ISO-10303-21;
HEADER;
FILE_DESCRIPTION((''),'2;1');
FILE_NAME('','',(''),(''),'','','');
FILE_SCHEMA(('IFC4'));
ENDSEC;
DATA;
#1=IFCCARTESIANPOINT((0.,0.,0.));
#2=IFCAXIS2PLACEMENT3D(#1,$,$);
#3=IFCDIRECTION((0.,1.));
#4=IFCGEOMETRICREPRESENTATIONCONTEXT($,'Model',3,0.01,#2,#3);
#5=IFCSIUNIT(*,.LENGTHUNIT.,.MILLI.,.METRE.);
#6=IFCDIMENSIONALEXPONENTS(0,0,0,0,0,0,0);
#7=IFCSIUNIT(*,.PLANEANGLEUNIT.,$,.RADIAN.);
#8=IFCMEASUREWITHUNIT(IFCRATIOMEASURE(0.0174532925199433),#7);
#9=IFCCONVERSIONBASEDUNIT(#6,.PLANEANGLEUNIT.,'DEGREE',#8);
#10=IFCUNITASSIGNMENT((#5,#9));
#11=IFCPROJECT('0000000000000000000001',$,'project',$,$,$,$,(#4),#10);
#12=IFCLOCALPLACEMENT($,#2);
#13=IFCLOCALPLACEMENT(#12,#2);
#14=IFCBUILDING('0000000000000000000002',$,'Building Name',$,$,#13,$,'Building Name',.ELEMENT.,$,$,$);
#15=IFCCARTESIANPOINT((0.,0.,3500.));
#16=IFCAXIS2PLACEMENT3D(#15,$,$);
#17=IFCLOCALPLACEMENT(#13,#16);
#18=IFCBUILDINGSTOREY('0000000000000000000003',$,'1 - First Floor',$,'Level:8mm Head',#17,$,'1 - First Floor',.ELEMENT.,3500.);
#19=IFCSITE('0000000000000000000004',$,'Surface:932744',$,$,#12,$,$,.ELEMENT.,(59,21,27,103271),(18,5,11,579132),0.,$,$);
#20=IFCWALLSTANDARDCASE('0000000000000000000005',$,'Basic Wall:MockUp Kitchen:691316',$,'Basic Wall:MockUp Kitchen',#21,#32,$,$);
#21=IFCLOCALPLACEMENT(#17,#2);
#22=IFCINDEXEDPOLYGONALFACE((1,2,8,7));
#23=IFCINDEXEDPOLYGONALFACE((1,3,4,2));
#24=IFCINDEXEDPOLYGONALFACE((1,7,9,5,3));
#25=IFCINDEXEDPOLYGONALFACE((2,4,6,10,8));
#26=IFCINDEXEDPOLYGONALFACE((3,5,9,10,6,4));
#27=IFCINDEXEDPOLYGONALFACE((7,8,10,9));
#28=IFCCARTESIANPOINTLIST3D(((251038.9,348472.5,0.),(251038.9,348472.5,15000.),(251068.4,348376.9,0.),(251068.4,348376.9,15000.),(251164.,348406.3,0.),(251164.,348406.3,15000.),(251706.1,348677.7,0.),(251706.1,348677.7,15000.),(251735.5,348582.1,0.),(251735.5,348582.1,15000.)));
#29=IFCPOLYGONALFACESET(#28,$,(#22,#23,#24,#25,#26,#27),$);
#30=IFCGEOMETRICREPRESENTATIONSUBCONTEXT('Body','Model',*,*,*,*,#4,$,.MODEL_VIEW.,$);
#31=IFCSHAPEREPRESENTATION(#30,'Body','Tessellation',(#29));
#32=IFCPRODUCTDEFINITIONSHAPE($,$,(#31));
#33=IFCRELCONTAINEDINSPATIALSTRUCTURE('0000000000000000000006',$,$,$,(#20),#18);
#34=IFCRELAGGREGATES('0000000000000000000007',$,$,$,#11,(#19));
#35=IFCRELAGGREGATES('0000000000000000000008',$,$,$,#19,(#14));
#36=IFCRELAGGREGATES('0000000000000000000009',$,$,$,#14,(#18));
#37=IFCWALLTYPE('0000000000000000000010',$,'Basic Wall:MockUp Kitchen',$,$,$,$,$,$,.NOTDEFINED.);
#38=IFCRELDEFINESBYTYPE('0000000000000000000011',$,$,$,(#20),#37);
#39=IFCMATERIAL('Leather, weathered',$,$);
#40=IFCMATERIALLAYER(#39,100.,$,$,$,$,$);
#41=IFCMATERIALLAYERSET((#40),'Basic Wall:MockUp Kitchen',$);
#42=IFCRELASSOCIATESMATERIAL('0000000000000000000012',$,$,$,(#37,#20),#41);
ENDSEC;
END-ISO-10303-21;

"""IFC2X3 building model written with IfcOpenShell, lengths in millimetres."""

from ifc_helpers import new_model, entity, si_unit, converted_unit, direction, frame, origin, place, context, subcontext, project, spatial, polyline, outline, extrude, material, layer, layer_set, layer_usage, type_object, element, save


model = new_model("IFC2X3")

# Units and contexts
model_context = context("Model", 3, precision=0.01, world=origin(), true_north=direction((0.0, 1.0)))
body_context = subcontext(model_context, "Body", "Model", "MODEL_VIEW")
ifc_project = project(units=[si_unit("LENGTHUNIT", "METRE", prefix="MILLI"), converted_unit("PLANEANGLEUNIT", "DEGREE", entity("IfcRatioMeasure", 0.0174532925199433), si_unit("PLANEANGLEUNIT", "RADIAN"), dimensions=[0, 0, 0, 0, 0, 0, 0])], contexts=[model_context])

# Site, building, storey
site_placement = place(None, origin())
site = spatial("IfcSite", under=ifc_project, at=site_placement, Name="Surface:932744", CompositionType="ELEMENT", RefLatitude=(59, 21, 27, 103271), RefLongitude=(18, 5, 11, 579132), RefElevation=0.0)
building_placement = place(site_placement, origin())
building = spatial("IfcBuilding", under=site, at=building_placement, Name="Building Name", LongName="Building Name", CompositionType="ELEMENT")
storey_placement = place(building_placement, frame((0.0, 0.0, 3500.0)))
storey = spatial("IfcBuildingStorey", under=building, at=storey_placement, Name="1 - First Floor", ObjectType="Level:8mm Head", LongName="1 - First Floor", CompositionType="ELEMENT", Elevation=3500.0)

# Shared definitions
ifc_material_1 = material(Name="Leather, weathered")

# Wall
ifc_layer_1 = layer(ifc_material_1, 100.0)
ifc_layer_set_1 = layer_set([ifc_layer_1], Name="Basic Wall:MockUp Kitchen")
wall_type_1 = type_object("IfcWallType", Name="Basic Wall:MockUp Kitchen", PredefinedType="NOTDEFINED", material=ifc_layer_set_1)
ifc_layer_usage_1 = layer_usage(ifc_layer_set_1, "AXIS2", "NEGATIVE", 50.0)
wall_1_placement = place(storey_placement, frame((251720.8, 348629.9, 0.0), z_axis=(0.0, 0.0, 1.0), x_axis=(-0.955818, -0.293958, 0.0)))
element("IfcWallStandardCase", 1, at=wall_1_placement, inside=storey, type_object=wall_type_1, material=ifc_layer_usage_1, Name="Basic Wall:MockUp Kitchen:691316", ObjectType="Basic Wall:MockUp Kitchen", context=body_context, shape_type="SweptSolid", body=[
    extrude(outline(polyline([(698.1, -50.0), (697.9, 50.0), (597.9, 50.0), (0.0, 50.0), (0.0, -50.0), (698.1, -50.0)])), origin(), (0.0, 0.0, 1.0), 15000.0),
])

save(model, "model.ifc")
